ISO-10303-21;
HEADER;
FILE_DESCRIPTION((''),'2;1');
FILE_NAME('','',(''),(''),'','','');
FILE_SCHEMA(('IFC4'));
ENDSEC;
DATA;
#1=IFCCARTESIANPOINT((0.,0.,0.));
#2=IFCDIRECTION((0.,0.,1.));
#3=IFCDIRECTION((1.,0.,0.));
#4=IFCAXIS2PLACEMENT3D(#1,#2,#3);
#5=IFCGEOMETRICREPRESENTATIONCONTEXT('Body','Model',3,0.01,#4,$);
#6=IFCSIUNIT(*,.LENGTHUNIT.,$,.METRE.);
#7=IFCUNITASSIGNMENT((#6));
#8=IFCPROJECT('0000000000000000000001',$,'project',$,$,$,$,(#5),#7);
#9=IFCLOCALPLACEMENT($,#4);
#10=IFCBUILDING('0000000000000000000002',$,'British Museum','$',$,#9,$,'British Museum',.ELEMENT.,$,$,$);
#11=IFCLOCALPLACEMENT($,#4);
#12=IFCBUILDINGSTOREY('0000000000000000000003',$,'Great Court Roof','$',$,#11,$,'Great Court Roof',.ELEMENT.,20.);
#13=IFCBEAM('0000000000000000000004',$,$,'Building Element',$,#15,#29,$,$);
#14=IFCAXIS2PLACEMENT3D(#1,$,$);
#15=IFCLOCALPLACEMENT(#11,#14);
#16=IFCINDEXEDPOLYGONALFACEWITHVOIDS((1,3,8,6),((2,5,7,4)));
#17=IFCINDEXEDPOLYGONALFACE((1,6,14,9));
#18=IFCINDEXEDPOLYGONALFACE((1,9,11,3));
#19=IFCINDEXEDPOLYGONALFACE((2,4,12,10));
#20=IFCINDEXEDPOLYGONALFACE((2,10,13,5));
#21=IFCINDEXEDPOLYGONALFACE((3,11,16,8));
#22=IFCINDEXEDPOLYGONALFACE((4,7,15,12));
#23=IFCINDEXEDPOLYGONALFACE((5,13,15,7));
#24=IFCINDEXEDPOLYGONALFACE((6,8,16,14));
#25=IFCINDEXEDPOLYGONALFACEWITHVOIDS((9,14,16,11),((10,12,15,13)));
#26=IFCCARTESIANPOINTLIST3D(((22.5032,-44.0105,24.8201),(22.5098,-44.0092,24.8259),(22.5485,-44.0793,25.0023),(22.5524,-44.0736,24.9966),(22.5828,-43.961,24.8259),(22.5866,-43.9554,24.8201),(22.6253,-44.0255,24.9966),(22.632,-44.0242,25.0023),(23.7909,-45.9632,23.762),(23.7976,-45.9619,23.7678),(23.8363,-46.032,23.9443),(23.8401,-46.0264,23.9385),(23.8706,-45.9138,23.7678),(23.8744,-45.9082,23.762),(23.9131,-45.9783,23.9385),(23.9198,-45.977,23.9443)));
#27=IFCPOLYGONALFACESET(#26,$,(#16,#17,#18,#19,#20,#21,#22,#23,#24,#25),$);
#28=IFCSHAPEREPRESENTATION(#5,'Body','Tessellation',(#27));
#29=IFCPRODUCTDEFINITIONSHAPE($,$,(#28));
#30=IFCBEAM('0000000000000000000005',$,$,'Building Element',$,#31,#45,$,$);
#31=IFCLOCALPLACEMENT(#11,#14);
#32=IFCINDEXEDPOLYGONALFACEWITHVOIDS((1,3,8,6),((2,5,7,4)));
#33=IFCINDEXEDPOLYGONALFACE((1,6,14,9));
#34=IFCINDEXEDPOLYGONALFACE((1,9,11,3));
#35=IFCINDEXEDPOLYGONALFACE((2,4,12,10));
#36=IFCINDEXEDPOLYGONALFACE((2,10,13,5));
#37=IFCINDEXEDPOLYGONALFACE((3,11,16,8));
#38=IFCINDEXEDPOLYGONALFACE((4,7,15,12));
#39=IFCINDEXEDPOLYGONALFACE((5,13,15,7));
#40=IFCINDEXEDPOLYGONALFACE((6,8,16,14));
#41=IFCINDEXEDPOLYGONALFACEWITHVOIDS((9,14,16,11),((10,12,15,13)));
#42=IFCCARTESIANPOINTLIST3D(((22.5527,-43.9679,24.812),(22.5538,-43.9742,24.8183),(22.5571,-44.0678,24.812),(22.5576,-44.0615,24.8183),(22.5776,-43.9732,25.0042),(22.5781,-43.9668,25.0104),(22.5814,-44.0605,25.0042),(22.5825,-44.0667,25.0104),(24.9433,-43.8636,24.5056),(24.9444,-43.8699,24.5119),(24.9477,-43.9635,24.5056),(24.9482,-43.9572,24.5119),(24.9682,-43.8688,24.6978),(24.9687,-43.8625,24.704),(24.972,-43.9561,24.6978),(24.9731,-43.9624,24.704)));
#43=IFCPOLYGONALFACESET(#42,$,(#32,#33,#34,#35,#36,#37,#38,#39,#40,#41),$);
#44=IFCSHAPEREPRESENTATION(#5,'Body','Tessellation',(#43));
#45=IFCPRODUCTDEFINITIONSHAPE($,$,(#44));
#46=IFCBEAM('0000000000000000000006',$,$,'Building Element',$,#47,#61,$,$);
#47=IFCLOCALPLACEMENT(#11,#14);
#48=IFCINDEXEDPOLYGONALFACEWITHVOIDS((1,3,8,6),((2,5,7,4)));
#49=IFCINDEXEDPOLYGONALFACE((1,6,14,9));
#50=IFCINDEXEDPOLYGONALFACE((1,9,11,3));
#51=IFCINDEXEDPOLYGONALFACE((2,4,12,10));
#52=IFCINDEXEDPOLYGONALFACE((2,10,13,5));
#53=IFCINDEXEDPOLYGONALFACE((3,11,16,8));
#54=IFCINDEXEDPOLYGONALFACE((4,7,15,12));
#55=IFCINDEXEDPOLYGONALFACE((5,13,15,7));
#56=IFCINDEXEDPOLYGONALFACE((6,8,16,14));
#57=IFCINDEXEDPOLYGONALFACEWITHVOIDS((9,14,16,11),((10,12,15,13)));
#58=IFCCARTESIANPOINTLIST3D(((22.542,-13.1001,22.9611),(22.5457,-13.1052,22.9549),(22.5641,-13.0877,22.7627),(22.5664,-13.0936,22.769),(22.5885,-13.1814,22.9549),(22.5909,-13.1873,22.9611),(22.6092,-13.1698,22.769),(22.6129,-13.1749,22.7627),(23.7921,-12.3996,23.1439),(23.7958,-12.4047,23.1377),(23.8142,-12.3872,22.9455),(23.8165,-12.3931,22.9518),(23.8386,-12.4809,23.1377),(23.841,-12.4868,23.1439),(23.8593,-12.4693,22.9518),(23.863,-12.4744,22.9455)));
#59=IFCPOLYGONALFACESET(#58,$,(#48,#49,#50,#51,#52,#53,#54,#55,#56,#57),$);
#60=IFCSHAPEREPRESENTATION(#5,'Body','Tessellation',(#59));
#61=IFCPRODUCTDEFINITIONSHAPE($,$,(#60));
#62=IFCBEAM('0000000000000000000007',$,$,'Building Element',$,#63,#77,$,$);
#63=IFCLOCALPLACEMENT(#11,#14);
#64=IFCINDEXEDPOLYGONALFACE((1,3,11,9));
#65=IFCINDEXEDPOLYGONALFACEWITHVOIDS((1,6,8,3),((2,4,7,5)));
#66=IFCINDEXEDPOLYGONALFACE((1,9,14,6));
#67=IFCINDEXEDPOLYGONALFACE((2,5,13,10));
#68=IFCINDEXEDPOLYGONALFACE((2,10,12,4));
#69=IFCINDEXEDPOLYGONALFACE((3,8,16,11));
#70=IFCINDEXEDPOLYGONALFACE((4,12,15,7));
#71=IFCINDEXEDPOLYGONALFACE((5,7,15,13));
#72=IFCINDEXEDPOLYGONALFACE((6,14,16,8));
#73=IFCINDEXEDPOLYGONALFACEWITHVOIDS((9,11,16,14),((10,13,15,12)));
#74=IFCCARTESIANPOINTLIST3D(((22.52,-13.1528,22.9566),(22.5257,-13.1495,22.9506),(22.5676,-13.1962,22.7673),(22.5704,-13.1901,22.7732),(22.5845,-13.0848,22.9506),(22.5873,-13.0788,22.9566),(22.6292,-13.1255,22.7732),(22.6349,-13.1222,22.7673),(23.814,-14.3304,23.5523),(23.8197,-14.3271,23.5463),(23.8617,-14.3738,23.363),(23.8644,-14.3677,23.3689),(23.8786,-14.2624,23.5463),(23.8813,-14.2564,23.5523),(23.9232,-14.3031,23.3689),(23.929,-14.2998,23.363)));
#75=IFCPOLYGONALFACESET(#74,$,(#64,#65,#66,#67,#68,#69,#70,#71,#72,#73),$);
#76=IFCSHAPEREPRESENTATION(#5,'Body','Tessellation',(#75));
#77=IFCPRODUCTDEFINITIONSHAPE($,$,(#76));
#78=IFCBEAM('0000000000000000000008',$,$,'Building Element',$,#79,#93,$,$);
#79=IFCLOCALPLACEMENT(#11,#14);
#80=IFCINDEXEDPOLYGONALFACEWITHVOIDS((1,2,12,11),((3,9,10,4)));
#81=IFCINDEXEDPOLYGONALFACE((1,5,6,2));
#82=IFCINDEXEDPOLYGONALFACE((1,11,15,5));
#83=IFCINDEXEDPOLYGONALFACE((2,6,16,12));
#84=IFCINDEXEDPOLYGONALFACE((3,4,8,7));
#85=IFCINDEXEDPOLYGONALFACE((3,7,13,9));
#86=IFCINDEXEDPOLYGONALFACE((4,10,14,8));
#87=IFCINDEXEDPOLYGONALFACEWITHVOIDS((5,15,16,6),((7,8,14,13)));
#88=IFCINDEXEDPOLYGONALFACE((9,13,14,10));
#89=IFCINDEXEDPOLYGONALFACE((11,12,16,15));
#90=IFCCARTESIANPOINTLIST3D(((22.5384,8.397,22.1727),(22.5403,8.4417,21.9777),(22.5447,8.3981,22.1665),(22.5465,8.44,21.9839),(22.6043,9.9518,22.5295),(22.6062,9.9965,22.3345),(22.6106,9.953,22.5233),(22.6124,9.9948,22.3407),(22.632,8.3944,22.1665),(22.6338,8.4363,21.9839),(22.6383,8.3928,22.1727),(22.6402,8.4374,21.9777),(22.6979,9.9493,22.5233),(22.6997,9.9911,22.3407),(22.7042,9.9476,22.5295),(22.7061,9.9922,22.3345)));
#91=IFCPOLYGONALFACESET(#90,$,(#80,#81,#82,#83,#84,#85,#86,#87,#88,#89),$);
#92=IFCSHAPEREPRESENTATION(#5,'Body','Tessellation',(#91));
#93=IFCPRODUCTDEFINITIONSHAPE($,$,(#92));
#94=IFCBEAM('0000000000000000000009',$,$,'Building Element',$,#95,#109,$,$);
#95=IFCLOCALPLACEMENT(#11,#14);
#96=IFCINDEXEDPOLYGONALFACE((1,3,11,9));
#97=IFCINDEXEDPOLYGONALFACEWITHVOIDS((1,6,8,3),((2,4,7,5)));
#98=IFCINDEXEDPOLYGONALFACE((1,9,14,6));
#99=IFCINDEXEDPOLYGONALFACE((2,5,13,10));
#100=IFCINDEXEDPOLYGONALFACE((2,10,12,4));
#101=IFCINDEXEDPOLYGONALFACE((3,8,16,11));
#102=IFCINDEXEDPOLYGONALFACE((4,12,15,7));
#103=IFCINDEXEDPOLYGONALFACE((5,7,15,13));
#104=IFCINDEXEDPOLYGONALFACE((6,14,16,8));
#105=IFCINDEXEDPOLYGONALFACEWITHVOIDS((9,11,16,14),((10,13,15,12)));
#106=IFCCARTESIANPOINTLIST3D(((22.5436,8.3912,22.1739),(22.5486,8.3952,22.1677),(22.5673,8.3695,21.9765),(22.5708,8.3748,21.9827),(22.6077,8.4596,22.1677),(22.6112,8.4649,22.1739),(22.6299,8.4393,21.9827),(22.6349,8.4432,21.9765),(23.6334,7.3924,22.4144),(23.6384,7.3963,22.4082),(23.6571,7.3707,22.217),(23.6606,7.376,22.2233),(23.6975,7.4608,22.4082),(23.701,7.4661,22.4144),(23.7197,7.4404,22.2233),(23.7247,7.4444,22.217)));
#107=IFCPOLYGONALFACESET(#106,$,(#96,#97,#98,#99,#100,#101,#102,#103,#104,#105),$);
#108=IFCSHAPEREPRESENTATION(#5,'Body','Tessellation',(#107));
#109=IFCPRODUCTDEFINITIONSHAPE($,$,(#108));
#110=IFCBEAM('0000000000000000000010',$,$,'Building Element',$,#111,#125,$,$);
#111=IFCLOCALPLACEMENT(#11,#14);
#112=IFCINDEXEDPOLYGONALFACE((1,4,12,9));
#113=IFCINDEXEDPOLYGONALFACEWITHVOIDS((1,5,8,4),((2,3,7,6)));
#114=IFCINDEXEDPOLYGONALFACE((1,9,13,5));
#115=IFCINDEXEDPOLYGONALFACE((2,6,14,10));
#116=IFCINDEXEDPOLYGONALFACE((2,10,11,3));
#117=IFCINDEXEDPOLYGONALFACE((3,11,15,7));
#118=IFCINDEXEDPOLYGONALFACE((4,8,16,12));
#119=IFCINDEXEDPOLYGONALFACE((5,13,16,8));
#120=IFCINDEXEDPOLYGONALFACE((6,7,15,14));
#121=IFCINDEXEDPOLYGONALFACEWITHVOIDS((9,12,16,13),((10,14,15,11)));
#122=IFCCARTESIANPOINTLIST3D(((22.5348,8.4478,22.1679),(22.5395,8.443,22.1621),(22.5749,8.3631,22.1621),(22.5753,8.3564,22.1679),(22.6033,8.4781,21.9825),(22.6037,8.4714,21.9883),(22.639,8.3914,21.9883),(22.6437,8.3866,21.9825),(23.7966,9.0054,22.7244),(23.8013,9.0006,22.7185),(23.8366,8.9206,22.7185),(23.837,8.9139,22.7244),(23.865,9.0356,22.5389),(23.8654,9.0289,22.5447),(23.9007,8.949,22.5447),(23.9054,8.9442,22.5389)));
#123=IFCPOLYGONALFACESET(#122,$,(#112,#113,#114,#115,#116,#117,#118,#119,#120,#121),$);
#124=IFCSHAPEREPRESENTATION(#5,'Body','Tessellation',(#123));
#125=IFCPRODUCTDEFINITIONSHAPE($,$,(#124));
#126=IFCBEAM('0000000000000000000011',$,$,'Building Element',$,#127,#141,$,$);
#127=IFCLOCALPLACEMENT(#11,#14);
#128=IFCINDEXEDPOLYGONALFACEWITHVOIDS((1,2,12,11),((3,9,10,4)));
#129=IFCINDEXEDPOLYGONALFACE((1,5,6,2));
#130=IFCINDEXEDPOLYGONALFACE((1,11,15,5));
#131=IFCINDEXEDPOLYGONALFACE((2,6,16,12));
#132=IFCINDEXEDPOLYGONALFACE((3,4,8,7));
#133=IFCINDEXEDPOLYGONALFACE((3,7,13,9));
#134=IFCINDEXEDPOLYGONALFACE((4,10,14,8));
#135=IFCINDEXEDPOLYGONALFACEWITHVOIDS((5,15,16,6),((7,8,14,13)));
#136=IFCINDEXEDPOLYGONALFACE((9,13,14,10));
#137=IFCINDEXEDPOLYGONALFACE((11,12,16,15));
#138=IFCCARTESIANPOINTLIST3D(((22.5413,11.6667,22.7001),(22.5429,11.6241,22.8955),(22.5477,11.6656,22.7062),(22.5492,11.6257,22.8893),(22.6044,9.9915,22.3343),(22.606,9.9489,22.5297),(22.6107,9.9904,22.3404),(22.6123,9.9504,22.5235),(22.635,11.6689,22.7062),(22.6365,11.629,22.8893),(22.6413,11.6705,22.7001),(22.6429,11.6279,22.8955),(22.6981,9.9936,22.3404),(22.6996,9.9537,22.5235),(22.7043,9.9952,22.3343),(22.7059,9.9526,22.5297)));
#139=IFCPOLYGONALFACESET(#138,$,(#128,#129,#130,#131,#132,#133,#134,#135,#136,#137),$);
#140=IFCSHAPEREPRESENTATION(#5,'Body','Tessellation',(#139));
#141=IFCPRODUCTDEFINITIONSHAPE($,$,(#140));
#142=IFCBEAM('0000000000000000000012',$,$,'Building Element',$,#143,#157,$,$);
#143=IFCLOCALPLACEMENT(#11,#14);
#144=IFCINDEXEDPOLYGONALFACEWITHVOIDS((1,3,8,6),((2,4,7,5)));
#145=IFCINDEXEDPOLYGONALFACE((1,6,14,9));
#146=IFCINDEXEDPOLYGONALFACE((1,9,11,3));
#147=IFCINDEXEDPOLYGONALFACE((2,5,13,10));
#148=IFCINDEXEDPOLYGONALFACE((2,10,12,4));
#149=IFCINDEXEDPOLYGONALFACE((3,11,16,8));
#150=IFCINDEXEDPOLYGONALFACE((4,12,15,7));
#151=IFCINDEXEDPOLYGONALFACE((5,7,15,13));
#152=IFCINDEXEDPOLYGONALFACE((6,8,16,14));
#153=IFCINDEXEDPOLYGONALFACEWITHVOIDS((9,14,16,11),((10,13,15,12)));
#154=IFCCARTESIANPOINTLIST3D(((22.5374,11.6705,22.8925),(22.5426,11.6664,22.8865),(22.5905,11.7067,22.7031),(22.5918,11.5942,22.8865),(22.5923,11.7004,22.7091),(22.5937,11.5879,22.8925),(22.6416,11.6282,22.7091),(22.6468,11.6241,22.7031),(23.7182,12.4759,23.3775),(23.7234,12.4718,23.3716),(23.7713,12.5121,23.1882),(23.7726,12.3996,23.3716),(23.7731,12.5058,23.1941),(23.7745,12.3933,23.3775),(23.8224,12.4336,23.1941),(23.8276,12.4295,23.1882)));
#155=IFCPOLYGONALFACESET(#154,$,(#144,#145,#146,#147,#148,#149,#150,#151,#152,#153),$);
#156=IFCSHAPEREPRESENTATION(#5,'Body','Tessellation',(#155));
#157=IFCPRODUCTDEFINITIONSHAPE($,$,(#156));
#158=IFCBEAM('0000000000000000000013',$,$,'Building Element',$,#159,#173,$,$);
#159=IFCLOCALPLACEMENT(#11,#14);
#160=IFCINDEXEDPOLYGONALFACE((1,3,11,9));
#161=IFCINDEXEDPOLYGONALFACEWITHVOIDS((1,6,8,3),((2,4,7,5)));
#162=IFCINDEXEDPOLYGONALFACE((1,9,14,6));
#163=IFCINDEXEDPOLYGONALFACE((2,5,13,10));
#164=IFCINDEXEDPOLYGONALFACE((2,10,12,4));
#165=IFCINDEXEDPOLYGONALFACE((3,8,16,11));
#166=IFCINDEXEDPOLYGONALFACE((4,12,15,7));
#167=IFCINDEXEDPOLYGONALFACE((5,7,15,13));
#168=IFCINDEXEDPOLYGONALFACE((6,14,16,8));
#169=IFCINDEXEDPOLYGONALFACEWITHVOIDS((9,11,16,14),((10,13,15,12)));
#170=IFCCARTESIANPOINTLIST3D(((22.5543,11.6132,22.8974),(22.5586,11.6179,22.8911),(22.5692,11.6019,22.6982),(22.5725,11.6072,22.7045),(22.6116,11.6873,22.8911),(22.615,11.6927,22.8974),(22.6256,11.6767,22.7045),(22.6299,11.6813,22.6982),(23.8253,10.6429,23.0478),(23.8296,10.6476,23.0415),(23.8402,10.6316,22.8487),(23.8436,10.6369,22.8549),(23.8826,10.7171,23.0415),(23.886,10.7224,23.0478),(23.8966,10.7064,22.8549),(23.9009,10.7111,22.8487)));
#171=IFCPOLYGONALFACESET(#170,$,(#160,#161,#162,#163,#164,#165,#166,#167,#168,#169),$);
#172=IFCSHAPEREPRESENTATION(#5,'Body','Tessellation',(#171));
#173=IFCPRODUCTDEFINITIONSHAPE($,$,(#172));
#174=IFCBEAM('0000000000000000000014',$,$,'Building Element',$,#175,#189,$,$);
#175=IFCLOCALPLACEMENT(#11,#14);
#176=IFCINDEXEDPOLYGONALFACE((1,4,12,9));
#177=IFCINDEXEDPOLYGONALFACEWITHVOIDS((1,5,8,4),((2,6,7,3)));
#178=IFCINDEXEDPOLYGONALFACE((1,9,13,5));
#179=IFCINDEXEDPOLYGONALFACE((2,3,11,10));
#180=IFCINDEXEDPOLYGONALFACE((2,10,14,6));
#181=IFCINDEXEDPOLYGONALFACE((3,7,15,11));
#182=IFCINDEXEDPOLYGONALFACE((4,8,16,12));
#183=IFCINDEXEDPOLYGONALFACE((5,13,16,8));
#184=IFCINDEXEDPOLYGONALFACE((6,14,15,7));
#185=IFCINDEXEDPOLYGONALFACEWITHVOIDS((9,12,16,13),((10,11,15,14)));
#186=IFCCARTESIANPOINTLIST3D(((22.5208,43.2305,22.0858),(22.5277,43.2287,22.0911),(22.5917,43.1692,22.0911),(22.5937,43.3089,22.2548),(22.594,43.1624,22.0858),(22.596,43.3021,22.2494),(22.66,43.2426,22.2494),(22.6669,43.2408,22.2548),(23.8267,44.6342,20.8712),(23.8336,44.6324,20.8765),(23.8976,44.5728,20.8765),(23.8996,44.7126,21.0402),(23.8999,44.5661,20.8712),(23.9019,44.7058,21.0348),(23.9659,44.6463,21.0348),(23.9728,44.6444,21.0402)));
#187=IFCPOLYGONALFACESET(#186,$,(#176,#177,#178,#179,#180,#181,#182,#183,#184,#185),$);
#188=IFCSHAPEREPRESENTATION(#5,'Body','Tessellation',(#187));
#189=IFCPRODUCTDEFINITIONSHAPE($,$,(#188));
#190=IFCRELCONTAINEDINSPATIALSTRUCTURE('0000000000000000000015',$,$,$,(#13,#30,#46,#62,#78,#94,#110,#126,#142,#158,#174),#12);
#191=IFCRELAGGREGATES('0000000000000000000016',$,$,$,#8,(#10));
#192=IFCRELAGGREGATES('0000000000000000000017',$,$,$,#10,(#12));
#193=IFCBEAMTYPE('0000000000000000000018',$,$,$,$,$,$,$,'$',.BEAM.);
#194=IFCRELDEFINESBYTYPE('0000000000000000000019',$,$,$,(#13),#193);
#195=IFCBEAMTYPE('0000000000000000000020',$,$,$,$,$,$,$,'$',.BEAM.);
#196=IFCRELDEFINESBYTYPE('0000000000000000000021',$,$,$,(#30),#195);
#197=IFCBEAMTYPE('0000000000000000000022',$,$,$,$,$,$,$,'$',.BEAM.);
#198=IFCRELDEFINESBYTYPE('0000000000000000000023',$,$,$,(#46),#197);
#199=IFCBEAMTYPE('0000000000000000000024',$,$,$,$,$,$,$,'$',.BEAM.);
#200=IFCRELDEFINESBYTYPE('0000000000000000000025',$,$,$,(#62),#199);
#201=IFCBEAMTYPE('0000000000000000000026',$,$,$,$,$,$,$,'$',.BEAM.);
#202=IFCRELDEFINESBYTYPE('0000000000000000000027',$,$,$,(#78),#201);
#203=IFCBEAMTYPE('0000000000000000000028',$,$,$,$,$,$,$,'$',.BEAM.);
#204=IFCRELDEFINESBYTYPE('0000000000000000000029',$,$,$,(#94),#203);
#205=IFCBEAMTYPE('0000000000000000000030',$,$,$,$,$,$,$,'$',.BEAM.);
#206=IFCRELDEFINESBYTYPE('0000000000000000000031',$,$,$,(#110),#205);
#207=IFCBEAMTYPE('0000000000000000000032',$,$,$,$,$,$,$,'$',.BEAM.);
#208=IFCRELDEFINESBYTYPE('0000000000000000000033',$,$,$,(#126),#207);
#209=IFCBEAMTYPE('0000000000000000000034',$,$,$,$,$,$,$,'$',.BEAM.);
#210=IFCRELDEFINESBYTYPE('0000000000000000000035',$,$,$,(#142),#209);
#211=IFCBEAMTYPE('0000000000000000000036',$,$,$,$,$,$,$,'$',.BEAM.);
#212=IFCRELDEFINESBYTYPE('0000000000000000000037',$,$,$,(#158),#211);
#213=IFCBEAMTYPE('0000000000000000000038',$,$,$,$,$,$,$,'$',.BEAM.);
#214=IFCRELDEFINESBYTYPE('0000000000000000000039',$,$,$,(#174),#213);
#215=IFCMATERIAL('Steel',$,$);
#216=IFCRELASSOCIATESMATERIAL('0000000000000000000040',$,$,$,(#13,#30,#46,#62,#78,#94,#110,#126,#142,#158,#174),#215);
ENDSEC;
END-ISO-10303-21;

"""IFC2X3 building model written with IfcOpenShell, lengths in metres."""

from ifc_helpers import new_model, si_unit, frame, origin_with_axes, origin_2d, place, context, project, spatial, hollow_rectangle, extrude, material, type_object, element, save


model = new_model("IFC2X3")

# Units and contexts
model_context = context("Model", 3, precision=0.01, world=origin_with_axes(), identifier="Body")
ifc_project = project(units=[si_unit("LENGTHUNIT", "METRE")], contexts=[model_context])

# Building, storey
building_placement = place(None, origin_with_axes())
building = spatial("IfcBuilding", under=ifc_project, at=building_placement, Name="British Museum", Description="$", LongName="British Museum", CompositionType="ELEMENT")
storey_placement = place(None, origin_with_axes())
storey = spatial("IfcBuildingStorey", under=building, at=storey_placement, Name="Great Court Roof", Description="$", LongName="Great Court Roof", CompositionType="ELEMENT", Elevation=20.0)

# Beams
ifc_material = material(Name="Steel")
beam_type_1 = type_object("IfcBeamType", ElementType="$", PredefinedType="BEAM")
beam_1_placement = place(None, origin_with_axes())
element("IfcBeam", 1, at=beam_1_placement, inside=storey, type_object=beam_type_1, material=ifc_material, Description="Building Element", context=model_context, shape_type="SweptSolid", body=[
    extrude(hollow_rectangle(XDim=0.1, YDim=0.2, WallThickness=0.0063, InnerFilletRadius=-0.0063, OuterFilletRadius=0.0, at=origin_2d()), frame((22.5676, -44.0173, 24.9112), z_axis=(0.501598, -0.760624, -0.41213), x_axis=(0.834818, 0.550526, 0.0)), (0.0, 0.0, 1.0), 2.5673),
])
beam_type_2 = type_object("IfcBeamType", ElementType="$", PredefinedType="BEAM")
beam_2_placement = place(None, origin_with_axes())
element("IfcBeam", 2, at=beam_2_placement, inside=storey, type_object=beam_type_2, material=ifc_material, Description="Building Element", context=model_context, shape_type="SweptSolid", body=[
    extrude(hollow_rectangle(XDim=0.1, YDim=0.2, WallThickness=0.0063, InnerFilletRadius=-0.0063, OuterFilletRadius=0.0, at=origin_2d()), frame((22.5676, -44.0173, 24.9112), z_axis=(0.990958, 0.043251, -0.127009), x_axis=(-0.043604, 0.999049, 0.0)), (0.0, 0.0, 1.0), 2.4124),
])
beam_type_3 = type_object("IfcBeamType", ElementType="$", PredefinedType="BEAM")
beam_3_placement = place(None, origin_with_axes())
element("IfcBeam", 3, at=beam_3_placement, inside=storey, type_object=beam_type_3, material=ifc_material, Description="Building Element", context=model_context, shape_type="SweptSolid", body=[
    extrude(hollow_rectangle(XDim=0.1, YDim=0.2, WallThickness=0.0063, InnerFilletRadius=-0.0063, OuterFilletRadius=0.0, at=origin_2d()), frame((22.5775, -13.1375, 22.8619), z_axis=(0.865362, 0.484908, 0.126541), x_axis=(-0.488837, 0.872375, 0.0)), (0.0, 0.0, 1.0), 1.4446),
])
beam_type_4 = type_object("IfcBeamType", ElementType="$", PredefinedType="BEAM")
beam_4_placement = place(None, origin_with_axes())
element("IfcBeam", 4, at=beam_4_placement, inside=storey, type_object=beam_type_4, material=ifc_material, Description="Building Element", context=model_context, shape_type="SweptSolid", body=[
    extrude(hollow_rectangle(XDim=0.1, YDim=0.2, WallThickness=0.0063, InnerFilletRadius=-0.0063, OuterFilletRadius=0.0, at=origin_2d()), frame((22.5775, -13.1375, 22.8619), z_axis=(0.700128, -0.637135, 0.322303), x_axis=(0.673051, 0.739596, 0.0)), (0.0, 0.0, 1.0), 1.8483),
])
beam_type_5 = type_object("IfcBeamType", ElementType="$", PredefinedType="BEAM")
beam_5_placement = place(None, origin_with_axes())
element("IfcBeam", 5, at=beam_5_placement, inside=storey, type_object=beam_type_5, material=ifc_material, Description="Building Element", context=model_context, shape_type="SweptSolid", body=[
    extrude(hollow_rectangle(XDim=0.1, YDim=0.2, WallThickness=0.0063, InnerFilletRadius=-0.0063, OuterFilletRadius=0.0, at=origin_2d()), frame((22.5893, 8.4172, 22.0752), z_axis=(0.04128, 0.973837, 0.223466), x_axis=(-0.999103, 0.042351, 0.0)), (0.0, 0.0, 1.0), 1.5966),
])
beam_type_6 = type_object("IfcBeamType", ElementType="$", PredefinedType="BEAM")
beam_6_placement = place(None, origin_with_axes())
element("IfcBeam", 6, at=beam_6_placement, inside=storey, type_object=beam_type_6, material=ifc_material, Description="Building Element", context=model_context, shape_type="SweptSolid", body=[
    extrude(hollow_rectangle(XDim=0.1, YDim=0.2, WallThickness=0.0063, InnerFilletRadius=-0.0063, OuterFilletRadius=0.0, at=origin_2d()), frame((22.5893, 8.4172, 22.0752), z_axis=(0.727629, -0.666906, 0.160601), x_axis=(0.675677, 0.737198, 0.0)), (0.0, 0.0, 1.0), 1.4977),
])
beam_type_7 = type_object("IfcBeamType", ElementType="$", PredefinedType="BEAM")
beam_7_placement = place(None, origin_with_axes())
element("IfcBeam", 7, at=beam_7_placement, inside=storey, type_object=beam_type_7, material=ifc_material, Description="Building Element", context=model_context, shape_type="SweptSolid", body=[
    extrude(hollow_rectangle(XDim=0.1, YDim=0.2, WallThickness=0.0063, InnerFilletRadius=-0.0063, OuterFilletRadius=0.0, at=origin_2d()), frame((22.5893, 8.4172, 22.0752), z_axis=(0.848262, 0.374844, 0.374091), x_axis=(-0.404191, 0.914674, 0.0)), (0.0, 0.0, 1.0), 1.4874),
])
beam_type_8 = type_object("IfcBeamType", ElementType="$", PredefinedType="BEAM")
beam_8_placement = place(None, origin_with_axes())
element("IfcBeam", 8, at=beam_8_placement, inside=storey, type_object=beam_type_8, material=ifc_material, Description="Building Element", context=model_context, shape_type="SweptSolid", body=[
    extrude(hollow_rectangle(XDim=0.1, YDim=0.2, WallThickness=0.0063, InnerFilletRadius=-0.0063, OuterFilletRadius=0.0, at=origin_2d()), frame((22.5921, 11.6473, 22.7978), z_axis=(0.036761, -0.97632, -0.213184), x_axis=(0.999292, 0.037626, 0.0)), (0.0, 0.0, 1.0), 1.7159),
])
beam_type_9 = type_object("IfcBeamType", ElementType="$", PredefinedType="BEAM")
beam_9_placement = place(None, origin_with_axes())
element("IfcBeam", 9, at=beam_9_placement, inside=storey, type_object=beam_type_9, material=ifc_material, Description="Building Element", context=model_context, shape_type="SweptSolid", body=[
    extrude(hollow_rectangle(XDim=0.1, YDim=0.2, WallThickness=0.0063, InnerFilletRadius=-0.0063, OuterFilletRadius=0.0, at=origin_2d()), frame((22.5921, 11.6473, 22.7978), z_axis=(0.7823, 0.533604, 0.32136), x_axis=(-0.563494, 0.82612, 0.0)), (0.0, 0.0, 1.0), 1.5094),
])
beam_type_10 = type_object("IfcBeamType", ElementType="$", PredefinedType="BEAM")
beam_10_placement = place(None, origin_with_axes())
element("IfcBeam", 10, at=beam_10_placement, inside=storey, type_object=beam_type_10, material=ifc_material, Description="Building Element", context=model_context, shape_type="SweptSolid", body=[
    extrude(hollow_rectangle(XDim=0.1, YDim=0.2, WallThickness=0.0063, InnerFilletRadius=-0.0063, OuterFilletRadius=0.0, at=origin_2d()), frame((22.5921, 11.6473, 22.7978), z_axis=(0.791363, -0.604129, 0.093658), x_axis=(0.606796, 0.794857, 0.0)), (0.0, 0.0, 1.0), 1.6061),
])
beam_type_11 = type_object("IfcBeamType", ElementType="$", PredefinedType="BEAM")
beam_11_placement = place(None, origin_with_axes())
element("IfcBeam", 11, at=beam_11_placement, inside=storey, type_object=beam_type_11, material=ifc_material, Description="Building Element", context=model_context, shape_type="SweptSolid", body=[
    extrude(hollow_rectangle(XDim=0.1, YDim=0.2, WallThickness=0.0063, InnerFilletRadius=-0.0063, OuterFilletRadius=0.0, at=origin_2d()), frame((22.5938, 43.2356, 22.1703), z_axis=(0.575404, 0.618472, -0.535166), x_axis=(-0.732139, 0.681156, 0.0)), (0.0, 0.0, 1.0), 2.2696),
])

save(model, "model.ifc")
